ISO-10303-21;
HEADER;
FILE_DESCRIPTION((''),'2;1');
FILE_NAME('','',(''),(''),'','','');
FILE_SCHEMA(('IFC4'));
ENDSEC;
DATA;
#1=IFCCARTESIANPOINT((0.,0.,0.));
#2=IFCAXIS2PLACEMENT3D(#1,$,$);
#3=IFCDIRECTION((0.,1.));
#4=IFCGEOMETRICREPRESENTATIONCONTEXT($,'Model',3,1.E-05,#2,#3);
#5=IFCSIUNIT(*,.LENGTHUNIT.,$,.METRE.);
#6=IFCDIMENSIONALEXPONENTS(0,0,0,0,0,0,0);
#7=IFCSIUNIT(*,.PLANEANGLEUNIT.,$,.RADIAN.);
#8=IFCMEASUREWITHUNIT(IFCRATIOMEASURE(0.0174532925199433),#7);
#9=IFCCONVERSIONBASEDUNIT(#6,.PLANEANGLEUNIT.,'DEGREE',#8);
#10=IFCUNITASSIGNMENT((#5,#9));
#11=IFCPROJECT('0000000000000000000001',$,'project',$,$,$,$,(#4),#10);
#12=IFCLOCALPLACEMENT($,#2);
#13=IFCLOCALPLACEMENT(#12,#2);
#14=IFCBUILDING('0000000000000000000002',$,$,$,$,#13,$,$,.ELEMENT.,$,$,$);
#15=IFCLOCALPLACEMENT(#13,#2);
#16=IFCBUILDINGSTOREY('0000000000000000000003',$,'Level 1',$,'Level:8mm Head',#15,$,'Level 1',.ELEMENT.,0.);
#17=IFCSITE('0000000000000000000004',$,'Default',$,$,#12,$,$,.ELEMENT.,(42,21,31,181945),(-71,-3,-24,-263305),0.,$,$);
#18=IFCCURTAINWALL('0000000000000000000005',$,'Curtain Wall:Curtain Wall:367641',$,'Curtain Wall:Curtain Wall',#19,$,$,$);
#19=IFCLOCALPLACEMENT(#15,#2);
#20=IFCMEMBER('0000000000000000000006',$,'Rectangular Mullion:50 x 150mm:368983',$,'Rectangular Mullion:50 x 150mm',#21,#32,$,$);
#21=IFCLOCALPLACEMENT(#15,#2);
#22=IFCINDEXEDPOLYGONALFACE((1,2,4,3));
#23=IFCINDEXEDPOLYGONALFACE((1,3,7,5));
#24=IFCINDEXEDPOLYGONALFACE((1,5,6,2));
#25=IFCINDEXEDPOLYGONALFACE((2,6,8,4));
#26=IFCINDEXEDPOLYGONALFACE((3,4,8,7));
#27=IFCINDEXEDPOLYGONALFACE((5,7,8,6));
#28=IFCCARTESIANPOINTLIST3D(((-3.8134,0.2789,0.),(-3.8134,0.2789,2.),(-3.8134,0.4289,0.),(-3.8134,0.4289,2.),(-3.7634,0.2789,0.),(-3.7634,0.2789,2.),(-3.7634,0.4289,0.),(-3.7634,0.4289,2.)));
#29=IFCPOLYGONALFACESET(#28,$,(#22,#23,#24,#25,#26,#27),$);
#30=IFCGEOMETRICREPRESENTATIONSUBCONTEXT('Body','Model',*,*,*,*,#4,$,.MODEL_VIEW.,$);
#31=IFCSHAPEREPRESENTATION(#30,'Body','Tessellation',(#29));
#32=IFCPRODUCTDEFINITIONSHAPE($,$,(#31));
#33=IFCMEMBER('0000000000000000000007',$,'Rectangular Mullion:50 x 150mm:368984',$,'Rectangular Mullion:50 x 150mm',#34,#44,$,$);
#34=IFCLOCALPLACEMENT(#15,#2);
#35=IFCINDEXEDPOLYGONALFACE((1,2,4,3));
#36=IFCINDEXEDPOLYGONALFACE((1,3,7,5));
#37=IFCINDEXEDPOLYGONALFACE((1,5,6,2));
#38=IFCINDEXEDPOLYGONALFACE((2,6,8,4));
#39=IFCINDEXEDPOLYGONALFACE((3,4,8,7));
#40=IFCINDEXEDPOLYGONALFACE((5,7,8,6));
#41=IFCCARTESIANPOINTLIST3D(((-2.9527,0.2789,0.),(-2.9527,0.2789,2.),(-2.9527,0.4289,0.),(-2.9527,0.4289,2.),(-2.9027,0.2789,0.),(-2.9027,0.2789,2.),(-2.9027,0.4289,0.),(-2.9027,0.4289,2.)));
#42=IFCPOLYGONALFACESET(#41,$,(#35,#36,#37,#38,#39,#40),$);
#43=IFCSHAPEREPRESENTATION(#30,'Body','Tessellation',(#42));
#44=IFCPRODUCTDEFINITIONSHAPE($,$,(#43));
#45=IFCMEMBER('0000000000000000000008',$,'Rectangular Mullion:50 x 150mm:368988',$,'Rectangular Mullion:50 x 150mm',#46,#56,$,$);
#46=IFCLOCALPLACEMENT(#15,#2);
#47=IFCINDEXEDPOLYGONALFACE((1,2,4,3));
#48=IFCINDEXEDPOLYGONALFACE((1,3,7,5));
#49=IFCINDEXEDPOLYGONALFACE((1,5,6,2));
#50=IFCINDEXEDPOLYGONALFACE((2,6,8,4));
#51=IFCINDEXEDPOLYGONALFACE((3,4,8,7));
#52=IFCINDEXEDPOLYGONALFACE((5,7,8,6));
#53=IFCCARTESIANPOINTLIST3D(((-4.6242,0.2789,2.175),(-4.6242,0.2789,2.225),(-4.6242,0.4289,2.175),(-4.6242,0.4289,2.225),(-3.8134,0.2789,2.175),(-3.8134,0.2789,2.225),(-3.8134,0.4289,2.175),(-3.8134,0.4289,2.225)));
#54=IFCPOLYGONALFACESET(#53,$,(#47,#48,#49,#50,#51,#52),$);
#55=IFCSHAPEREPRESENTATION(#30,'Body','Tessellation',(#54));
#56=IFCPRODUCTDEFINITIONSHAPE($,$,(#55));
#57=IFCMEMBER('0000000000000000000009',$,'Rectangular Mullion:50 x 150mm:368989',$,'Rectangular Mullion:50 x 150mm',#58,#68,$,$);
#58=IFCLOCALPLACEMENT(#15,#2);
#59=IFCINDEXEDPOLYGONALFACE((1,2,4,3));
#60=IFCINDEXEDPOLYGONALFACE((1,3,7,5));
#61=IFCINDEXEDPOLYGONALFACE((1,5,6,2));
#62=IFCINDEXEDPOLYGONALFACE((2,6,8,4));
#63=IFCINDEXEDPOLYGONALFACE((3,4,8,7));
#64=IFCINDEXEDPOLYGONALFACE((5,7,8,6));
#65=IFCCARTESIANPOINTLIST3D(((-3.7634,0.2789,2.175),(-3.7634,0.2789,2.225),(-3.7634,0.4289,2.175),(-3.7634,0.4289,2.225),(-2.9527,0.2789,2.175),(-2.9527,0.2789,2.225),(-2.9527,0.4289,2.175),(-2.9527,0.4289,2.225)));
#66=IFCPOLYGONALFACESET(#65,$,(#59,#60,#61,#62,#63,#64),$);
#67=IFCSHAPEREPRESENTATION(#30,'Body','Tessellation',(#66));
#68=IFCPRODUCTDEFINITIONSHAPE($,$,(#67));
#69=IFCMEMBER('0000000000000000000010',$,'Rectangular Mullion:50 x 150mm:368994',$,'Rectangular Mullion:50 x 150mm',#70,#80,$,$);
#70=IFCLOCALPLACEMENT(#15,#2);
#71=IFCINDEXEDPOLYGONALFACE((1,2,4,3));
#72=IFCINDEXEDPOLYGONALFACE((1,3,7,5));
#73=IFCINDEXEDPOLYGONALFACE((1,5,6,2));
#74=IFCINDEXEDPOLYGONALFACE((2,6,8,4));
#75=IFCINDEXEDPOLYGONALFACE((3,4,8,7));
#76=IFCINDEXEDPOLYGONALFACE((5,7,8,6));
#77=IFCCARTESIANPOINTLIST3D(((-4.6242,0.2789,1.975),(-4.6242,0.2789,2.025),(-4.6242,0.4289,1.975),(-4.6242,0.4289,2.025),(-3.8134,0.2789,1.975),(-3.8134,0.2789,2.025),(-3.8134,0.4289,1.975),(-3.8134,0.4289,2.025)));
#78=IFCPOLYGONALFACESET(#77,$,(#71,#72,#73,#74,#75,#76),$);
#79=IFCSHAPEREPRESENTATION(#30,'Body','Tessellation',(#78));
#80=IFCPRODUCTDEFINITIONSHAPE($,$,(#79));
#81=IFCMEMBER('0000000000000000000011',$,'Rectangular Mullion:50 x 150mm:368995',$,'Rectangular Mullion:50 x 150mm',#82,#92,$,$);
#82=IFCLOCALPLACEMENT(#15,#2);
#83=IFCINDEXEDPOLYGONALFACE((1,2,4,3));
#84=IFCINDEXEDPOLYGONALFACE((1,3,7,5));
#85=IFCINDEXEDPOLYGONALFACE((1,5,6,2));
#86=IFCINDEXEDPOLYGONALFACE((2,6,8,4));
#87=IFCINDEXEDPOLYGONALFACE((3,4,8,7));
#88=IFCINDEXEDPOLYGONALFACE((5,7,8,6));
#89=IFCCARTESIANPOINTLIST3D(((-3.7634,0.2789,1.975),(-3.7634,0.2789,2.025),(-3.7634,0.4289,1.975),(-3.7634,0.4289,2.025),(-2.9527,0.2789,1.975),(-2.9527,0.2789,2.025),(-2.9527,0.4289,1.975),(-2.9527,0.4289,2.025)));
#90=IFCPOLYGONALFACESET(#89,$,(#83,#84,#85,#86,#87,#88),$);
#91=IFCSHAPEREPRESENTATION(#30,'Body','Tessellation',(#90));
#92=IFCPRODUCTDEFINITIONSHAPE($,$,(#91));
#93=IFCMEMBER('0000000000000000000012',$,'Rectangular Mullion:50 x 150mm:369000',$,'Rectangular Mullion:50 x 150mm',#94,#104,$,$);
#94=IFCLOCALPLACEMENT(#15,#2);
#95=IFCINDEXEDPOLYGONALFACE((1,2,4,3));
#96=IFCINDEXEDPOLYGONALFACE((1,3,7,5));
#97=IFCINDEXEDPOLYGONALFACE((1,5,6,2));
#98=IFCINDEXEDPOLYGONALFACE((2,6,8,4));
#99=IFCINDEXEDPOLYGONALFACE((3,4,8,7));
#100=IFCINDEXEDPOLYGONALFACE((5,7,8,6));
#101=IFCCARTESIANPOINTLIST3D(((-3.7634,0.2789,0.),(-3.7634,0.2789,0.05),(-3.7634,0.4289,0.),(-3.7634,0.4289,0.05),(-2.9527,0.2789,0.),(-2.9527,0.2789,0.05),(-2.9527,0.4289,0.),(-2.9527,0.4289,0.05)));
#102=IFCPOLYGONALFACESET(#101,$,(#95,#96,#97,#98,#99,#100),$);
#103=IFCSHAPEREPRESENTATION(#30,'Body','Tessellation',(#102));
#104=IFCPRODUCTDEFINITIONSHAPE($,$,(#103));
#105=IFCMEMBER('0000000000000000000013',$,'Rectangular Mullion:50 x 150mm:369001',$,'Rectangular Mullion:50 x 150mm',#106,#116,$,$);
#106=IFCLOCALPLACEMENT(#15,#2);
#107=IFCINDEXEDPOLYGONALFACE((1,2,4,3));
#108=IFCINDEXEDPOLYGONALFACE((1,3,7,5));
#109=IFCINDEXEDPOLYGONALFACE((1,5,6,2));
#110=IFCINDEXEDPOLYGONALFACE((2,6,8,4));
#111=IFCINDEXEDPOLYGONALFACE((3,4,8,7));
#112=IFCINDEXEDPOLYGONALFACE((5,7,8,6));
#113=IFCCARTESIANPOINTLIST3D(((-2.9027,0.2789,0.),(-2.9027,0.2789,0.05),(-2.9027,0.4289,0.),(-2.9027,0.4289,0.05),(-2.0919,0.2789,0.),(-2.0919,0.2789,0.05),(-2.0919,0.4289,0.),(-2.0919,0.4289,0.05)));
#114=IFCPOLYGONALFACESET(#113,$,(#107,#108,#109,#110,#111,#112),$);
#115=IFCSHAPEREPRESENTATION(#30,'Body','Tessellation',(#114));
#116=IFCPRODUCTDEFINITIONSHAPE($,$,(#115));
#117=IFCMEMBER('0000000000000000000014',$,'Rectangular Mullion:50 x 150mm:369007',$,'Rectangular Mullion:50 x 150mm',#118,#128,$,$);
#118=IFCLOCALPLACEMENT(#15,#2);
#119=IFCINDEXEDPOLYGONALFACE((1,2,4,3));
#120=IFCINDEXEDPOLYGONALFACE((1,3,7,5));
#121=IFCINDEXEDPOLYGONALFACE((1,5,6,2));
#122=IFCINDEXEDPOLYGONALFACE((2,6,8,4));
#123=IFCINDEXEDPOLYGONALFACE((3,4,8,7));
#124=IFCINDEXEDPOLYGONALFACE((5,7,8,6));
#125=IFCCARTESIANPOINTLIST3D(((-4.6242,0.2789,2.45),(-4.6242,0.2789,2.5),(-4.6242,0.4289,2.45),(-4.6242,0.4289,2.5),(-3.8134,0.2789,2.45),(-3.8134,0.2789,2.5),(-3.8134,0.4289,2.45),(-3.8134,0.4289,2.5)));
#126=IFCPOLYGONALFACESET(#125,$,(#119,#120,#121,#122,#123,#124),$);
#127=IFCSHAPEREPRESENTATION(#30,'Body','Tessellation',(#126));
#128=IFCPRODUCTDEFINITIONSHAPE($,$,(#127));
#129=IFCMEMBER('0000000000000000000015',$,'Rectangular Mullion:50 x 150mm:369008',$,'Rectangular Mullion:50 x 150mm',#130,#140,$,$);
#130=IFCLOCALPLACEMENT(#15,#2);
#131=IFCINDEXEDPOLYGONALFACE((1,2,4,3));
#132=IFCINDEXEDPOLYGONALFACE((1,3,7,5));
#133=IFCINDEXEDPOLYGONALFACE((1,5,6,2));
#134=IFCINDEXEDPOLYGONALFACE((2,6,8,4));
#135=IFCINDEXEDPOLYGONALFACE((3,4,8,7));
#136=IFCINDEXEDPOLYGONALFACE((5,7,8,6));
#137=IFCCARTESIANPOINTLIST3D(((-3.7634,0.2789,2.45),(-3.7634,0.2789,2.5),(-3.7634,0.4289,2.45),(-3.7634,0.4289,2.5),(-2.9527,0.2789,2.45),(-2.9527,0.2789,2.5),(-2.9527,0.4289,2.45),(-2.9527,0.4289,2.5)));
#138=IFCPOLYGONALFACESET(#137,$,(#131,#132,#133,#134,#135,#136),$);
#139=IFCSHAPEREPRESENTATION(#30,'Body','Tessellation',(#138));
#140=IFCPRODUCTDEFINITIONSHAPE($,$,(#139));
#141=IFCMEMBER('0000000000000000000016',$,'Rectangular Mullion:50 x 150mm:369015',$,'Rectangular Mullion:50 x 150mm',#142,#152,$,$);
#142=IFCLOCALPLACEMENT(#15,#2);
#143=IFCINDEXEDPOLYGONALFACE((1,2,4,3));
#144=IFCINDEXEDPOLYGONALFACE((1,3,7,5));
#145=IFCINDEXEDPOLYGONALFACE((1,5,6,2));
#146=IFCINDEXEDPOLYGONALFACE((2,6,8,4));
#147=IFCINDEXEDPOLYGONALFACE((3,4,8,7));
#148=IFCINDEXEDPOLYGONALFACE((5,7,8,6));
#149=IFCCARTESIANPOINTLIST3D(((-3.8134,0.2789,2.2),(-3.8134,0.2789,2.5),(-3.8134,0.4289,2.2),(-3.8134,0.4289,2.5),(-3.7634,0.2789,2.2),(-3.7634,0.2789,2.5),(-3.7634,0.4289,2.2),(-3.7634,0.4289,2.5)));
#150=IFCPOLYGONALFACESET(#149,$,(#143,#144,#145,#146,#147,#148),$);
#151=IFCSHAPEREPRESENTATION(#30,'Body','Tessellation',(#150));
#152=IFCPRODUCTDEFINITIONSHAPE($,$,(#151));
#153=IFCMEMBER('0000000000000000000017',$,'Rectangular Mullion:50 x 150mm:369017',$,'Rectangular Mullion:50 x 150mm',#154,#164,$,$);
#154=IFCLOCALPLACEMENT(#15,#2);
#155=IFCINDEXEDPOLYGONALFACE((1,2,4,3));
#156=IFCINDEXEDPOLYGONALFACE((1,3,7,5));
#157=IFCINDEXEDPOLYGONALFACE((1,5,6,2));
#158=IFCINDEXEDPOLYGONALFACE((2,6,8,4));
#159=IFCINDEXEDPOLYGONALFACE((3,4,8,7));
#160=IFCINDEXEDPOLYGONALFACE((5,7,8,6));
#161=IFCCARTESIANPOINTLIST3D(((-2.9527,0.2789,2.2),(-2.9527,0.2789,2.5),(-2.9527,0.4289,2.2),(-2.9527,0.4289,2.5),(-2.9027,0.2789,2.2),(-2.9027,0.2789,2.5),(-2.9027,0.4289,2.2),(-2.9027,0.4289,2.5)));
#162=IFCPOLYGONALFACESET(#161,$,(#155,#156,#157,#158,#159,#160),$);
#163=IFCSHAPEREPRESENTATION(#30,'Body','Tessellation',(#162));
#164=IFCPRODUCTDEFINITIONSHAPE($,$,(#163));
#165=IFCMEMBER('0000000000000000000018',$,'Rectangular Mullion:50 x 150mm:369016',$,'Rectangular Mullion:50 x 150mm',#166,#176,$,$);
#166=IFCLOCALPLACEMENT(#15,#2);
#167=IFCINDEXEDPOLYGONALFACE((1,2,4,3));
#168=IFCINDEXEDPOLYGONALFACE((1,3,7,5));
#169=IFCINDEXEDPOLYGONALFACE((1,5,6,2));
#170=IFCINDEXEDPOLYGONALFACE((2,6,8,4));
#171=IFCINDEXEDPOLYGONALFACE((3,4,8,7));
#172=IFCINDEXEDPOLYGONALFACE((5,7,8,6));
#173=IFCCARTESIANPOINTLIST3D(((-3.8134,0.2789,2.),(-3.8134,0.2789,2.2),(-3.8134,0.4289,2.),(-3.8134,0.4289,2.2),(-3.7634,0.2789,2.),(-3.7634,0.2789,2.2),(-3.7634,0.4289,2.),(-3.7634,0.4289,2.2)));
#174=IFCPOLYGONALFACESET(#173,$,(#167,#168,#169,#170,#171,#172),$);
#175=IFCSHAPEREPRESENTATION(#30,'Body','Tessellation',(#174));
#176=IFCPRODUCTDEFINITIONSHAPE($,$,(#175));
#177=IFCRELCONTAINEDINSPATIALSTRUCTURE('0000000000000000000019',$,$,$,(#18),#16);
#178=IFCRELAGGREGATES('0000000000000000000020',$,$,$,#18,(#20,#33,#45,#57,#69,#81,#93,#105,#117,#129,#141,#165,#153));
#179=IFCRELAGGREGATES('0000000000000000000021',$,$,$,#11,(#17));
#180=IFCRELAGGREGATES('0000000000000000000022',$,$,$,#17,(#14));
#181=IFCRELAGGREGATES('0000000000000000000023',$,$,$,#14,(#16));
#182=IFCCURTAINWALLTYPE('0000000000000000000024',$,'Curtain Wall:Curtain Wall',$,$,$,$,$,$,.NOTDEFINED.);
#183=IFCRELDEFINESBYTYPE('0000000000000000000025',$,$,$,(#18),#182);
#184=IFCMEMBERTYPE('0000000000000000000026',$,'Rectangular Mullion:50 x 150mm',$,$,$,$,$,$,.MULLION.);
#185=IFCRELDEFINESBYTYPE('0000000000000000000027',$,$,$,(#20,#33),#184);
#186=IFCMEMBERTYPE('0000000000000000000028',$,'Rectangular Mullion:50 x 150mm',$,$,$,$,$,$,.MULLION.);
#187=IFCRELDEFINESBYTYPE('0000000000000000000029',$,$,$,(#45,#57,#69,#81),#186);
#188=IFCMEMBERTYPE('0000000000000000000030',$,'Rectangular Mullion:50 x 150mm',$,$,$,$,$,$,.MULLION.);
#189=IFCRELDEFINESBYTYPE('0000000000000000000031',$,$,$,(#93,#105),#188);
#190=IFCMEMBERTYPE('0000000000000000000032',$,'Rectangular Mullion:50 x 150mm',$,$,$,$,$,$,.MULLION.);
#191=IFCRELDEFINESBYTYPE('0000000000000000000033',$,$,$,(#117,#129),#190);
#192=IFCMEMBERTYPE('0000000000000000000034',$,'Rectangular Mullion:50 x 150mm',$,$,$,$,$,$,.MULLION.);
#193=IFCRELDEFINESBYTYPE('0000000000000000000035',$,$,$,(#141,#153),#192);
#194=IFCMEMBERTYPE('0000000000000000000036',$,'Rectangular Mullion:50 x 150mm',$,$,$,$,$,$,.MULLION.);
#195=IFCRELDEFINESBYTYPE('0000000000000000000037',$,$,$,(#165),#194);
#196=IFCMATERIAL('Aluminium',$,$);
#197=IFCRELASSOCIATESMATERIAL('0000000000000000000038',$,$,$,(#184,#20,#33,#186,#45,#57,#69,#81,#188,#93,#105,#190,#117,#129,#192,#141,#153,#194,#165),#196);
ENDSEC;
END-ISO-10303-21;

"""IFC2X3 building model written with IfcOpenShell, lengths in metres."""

from ifc_helpers import new_model, entity, si_unit, converted_unit, direction, frame, origin, origin_2d_with_axis, place, context, subcontext, project, spatial, rectangle, extrude, source, transform, mapped, material, type_object, type_shapes, element, aggregate, save


model = new_model("IFC2X3")

# Units and contexts
model_context = context("Model", 3, precision=1e-05, world=origin(), true_north=direction((0.0, 1.0)))
body_context = subcontext(model_context, "Body", "Model", "MODEL_VIEW")
ifc_project = project(units=[si_unit("LENGTHUNIT", "METRE"), converted_unit("PLANEANGLEUNIT", "DEGREE", entity("IfcRatioMeasure", 0.0174532925199433), si_unit("PLANEANGLEUNIT", "RADIAN"), dimensions=[0, 0, 0, 0, 0, 0, 0])], contexts=[model_context])

# Site, building, storey
site_placement = place(None, origin())
site = spatial("IfcSite", under=ifc_project, at=site_placement, Name="Default", CompositionType="ELEMENT", RefLatitude=(42, 21, 31, 181945), RefLongitude=(-71, -3, -24, -263305), RefElevation=0.0)
building_placement = place(site_placement, origin())
building = spatial("IfcBuilding", under=site, at=building_placement, CompositionType="ELEMENT")
storey_placement = place(building_placement, origin())
storey = spatial("IfcBuildingStorey", under=building, at=storey_placement, Name="Level 1", ObjectType="Level:8mm Head", LongName="Level 1", CompositionType="ELEMENT", Elevation=0.0)

# Curtain wall, members
curtain_wall_type = type_object("IfcCurtainWallType", Name="Curtain Wall:Curtain Wall", PredefinedType="NOTDEFINED")
curtain_wall_placement = place(storey_placement, origin())
curtain_wall = element("IfcCurtainWall", 1, at=curtain_wall_placement, inside=storey, type_object=curtain_wall_type, Name="Curtain Wall:Curtain Wall:367641", ObjectType="Curtain Wall:Curtain Wall")
ifc_material_1 = material(Name="Aluminium")
member_type_1 = type_object("IfcMemberType", Name="Rectangular Mullion:50 x 150mm", PredefinedType="MULLION", material=ifc_material_1)
shared_shape_1 = source(origin(), body_context, "Body", "SweptSolid", [
    extrude(rectangle(XDim=0.15, YDim=0.05, at=origin_2d_with_axis()), frame((0.0, 0.0, -2.0), z_axis=(0.0, 0.0, 1.0), x_axis=(0.0, -1.0, 0.0)), (0.0, 0.0, 1.0), 2.0),
])
type_shapes(member_type_1, [shared_shape_1])
member_1_placement = place(storey_placement, frame((-3.7884, 0.3539, 0.0), z_axis=(0.0, 0.0, -1.0), x_axis=(1.0, 0.0, 0.0)))
member_1 = element("IfcMember", 2, at=member_1_placement, type_object=member_type_1, material=ifc_material_1, Name="Rectangular Mullion:50 x 150mm:368983", ObjectType="Rectangular Mullion:50 x 150mm", context=body_context, shape_type="MappedRepresentation", body=[
    mapped(shared_shape_1, transform((0.0, 0.0, 0.0), scale=1.0)),
])
member_2_placement = place(storey_placement, frame((-2.9277, 0.3539, 0.0), z_axis=(0.0, 0.0, -1.0), x_axis=(1.0, 0.0, 0.0)))
member_2 = element("IfcMember", 3, at=member_2_placement, type_object=member_type_1, material=ifc_material_1, Name="Rectangular Mullion:50 x 150mm:368984", ObjectType="Rectangular Mullion:50 x 150mm", context=body_context, shape_type="MappedRepresentation", body=[
    mapped(shared_shape_1, transform((0.0, 0.0, 0.0), scale=1.0)),
])
member_type_2 = type_object("IfcMemberType", Name="Rectangular Mullion:50 x 150mm", PredefinedType="MULLION", material=ifc_material_1)
shared_shape_2 = source(origin(), body_context, "Body", "SweptSolid", [
    extrude(rectangle(XDim=0.15, YDim=0.05, at=origin_2d_with_axis()), frame((0.0, 0.0, -0.8107), z_axis=(0.0, 0.0, 1.0), x_axis=(0.0, -1.0, 0.0)), (0.0, 0.0, 1.0), 0.8107),
])
type_shapes(member_type_2, [shared_shape_2])
member_3_placement = place(storey_placement, frame((-3.8134, 0.3539, 2.2), z_axis=(1.0, 0.0, 0.0), x_axis=(0.0, 0.0, 1.0)))
member_3 = element("IfcMember", 4, at=member_3_placement, type_object=member_type_2, material=ifc_material_1, Name="Rectangular Mullion:50 x 150mm:368988", ObjectType="Rectangular Mullion:50 x 150mm", context=body_context, shape_type="MappedRepresentation", body=[
    mapped(shared_shape_2, transform((0.0, 0.0, 0.0), scale=1.0)),
])
member_4_placement = place(storey_placement, frame((-2.9527, 0.3539, 2.2), z_axis=(1.0, 0.0, 0.0), x_axis=(0.0, 0.0, 1.0)))
member_4 = element("IfcMember", 5, at=member_4_placement, type_object=member_type_2, material=ifc_material_1, Name="Rectangular Mullion:50 x 150mm:368989", ObjectType="Rectangular Mullion:50 x 150mm", context=body_context, shape_type="MappedRepresentation", body=[
    mapped(shared_shape_2, transform((0.0, 0.0, 0.0), scale=1.0)),
])
member_5_placement = place(storey_placement, frame((-3.8134, 0.3539, 2.0), z_axis=(1.0, 0.0, 0.0), x_axis=(0.0, 0.0, 1.0)))
member_5 = element("IfcMember", 6, at=member_5_placement, type_object=member_type_2, material=ifc_material_1, Name="Rectangular Mullion:50 x 150mm:368994", ObjectType="Rectangular Mullion:50 x 150mm", context=body_context, shape_type="MappedRepresentation", body=[
    mapped(shared_shape_2, transform((0.0, 0.0, 0.0), scale=1.0)),
])
member_6_placement = place(storey_placement, frame((-2.9527, 0.3539, 2.0), z_axis=(1.0, 0.0, 0.0), x_axis=(0.0, 0.0, 1.0)))
member_6 = element("IfcMember", 7, at=member_6_placement, type_object=member_type_2, material=ifc_material_1, Name="Rectangular Mullion:50 x 150mm:368995", ObjectType="Rectangular Mullion:50 x 150mm", context=body_context, shape_type="MappedRepresentation", body=[
    mapped(shared_shape_2, transform((0.0, 0.0, 0.0), scale=1.0)),
])
member_type_3 = type_object("IfcMemberType", Name="Rectangular Mullion:50 x 150mm", PredefinedType="MULLION", material=ifc_material_1)
shared_shape_3 = source(origin(), body_context, "Body", "SweptSolid", [
    extrude(rectangle(XDim=0.15, YDim=0.05, at=origin_2d_with_axis()), frame((-0.025, 0.0, -0.8107), z_axis=(0.0, 0.0, 1.0), x_axis=(0.0, -1.0, 0.0)), (0.0, 0.0, 1.0), 0.8107),
])
type_shapes(member_type_3, [shared_shape_3])
member_7_placement = place(storey_placement, frame((-3.7634, 0.3539, 0.0), z_axis=(-1.0, 0.0, 0.0), x_axis=(0.0, 0.0, -1.0)))
member_7 = element("IfcMember", 8, at=member_7_placement, type_object=member_type_3, material=ifc_material_1, Name="Rectangular Mullion:50 x 150mm:369000", ObjectType="Rectangular Mullion:50 x 150mm", context=body_context, shape_type="MappedRepresentation", body=[
    mapped(shared_shape_3, transform((0.0, 0.0, 0.0), scale=1.0)),
])
member_8_placement = place(storey_placement, frame((-2.9027, 0.3539, 0.0), z_axis=(-1.0, 0.0, 0.0), x_axis=(0.0, 0.0, -1.0)))
member_8 = element("IfcMember", 9, at=member_8_placement, type_object=member_type_3, material=ifc_material_1, Name="Rectangular Mullion:50 x 150mm:369001", ObjectType="Rectangular Mullion:50 x 150mm", context=body_context, shape_type="MappedRepresentation", body=[
    mapped(shared_shape_3, transform((0.0, 0.0, 0.0), scale=1.0)),
])
member_type_4 = type_object("IfcMemberType", Name="Rectangular Mullion:50 x 150mm", PredefinedType="MULLION", material=ifc_material_1)
shared_shape_4 = source(origin(), body_context, "Body", "SweptSolid", [
    extrude(rectangle(XDim=0.15, YDim=0.05, at=origin_2d_with_axis()), frame((-0.025, 0.0, -0.8107), z_axis=(0.0, 0.0, 1.0), x_axis=(0.0, -1.0, 0.0)), (0.0, 0.0, 1.0), 0.8107),
])
type_shapes(member_type_4, [shared_shape_4])
member_9_placement = place(storey_placement, frame((-3.8134, 0.3539, 2.5), z_axis=(1.0, 0.0, 0.0), x_axis=(0.0, 0.0, 1.0)))
member_9 = element("IfcMember", 10, at=member_9_placement, type_object=member_type_4, material=ifc_material_1, Name="Rectangular Mullion:50 x 150mm:369007", ObjectType="Rectangular Mullion:50 x 150mm", context=body_context, shape_type="MappedRepresentation", body=[
    mapped(shared_shape_4, transform((0.0, 0.0, 0.0), scale=1.0)),
])
member_10_placement = place(storey_placement, frame((-2.9527, 0.3539, 2.5), z_axis=(1.0, 0.0, 0.0), x_axis=(0.0, 0.0, 1.0)))
member_10 = element("IfcMember", 11, at=member_10_placement, type_object=member_type_4, material=ifc_material_1, Name="Rectangular Mullion:50 x 150mm:369008", ObjectType="Rectangular Mullion:50 x 150mm", context=body_context, shape_type="MappedRepresentation", body=[
    mapped(shared_shape_4, transform((0.0, 0.0, 0.0), scale=1.0)),
])
member_type_5 = type_object("IfcMemberType", Name="Rectangular Mullion:50 x 150mm", PredefinedType="MULLION", material=ifc_material_1)
shared_shape_5 = source(origin(), body_context, "Body", "SweptSolid", [
    extrude(rectangle(XDim=0.15, YDim=0.05, at=origin_2d_with_axis()), frame((0.0, 0.0, -0.3), z_axis=(0.0, 0.0, 1.0), x_axis=(0.0, -1.0, 0.0)), (0.0, 0.0, 1.0), 0.3),
])
type_shapes(member_type_5, [shared_shape_5])
member_11_placement = place(storey_placement, frame((-3.7884, 0.3539, 2.2), z_axis=(0.0, 0.0, -1.0), x_axis=(1.0, 0.0, 0.0)))
member_11 = element("IfcMember", 12, at=member_11_placement, type_object=member_type_5, material=ifc_material_1, Name="Rectangular Mullion:50 x 150mm:369015", ObjectType="Rectangular Mullion:50 x 150mm", context=body_context, shape_type="MappedRepresentation", body=[
    mapped(shared_shape_5, transform((0.0, 0.0, 0.0), scale=1.0)),
])
member_12_placement = place(storey_placement, frame((-2.9277, 0.3539, 2.2), z_axis=(0.0, 0.0, -1.0), x_axis=(1.0, 0.0, 0.0)))
member_12 = element("IfcMember", 13, at=member_12_placement, type_object=member_type_5, material=ifc_material_1, Name="Rectangular Mullion:50 x 150mm:369017", ObjectType="Rectangular Mullion:50 x 150mm", context=body_context, shape_type="MappedRepresentation", body=[
    mapped(shared_shape_5, transform((0.0, 0.0, 0.0), scale=1.0)),
])
member_type_6 = type_object("IfcMemberType", Name="Rectangular Mullion:50 x 150mm", PredefinedType="MULLION", material=ifc_material_1)
shared_shape_6 = source(origin(), body_context, "Body", "SweptSolid", [
    extrude(rectangle(XDim=0.15, YDim=0.05, at=origin_2d_with_axis()), frame((0.0, 0.0, -0.2), z_axis=(0.0, 0.0, 1.0), x_axis=(0.0, -1.0, 0.0)), (0.0, 0.0, 1.0), 0.2),
])
type_shapes(member_type_6, [shared_shape_6])
member_13_placement = place(storey_placement, frame((-3.7884, 0.3539, 2.0), z_axis=(0.0, 0.0, -1.0), x_axis=(1.0, 0.0, 0.0)))
member_13 = element("IfcMember", 14, at=member_13_placement, type_object=member_type_6, material=ifc_material_1, Name="Rectangular Mullion:50 x 150mm:369016", ObjectType="Rectangular Mullion:50 x 150mm", context=body_context, shape_type="MappedRepresentation", body=[
    mapped(shared_shape_6, transform((0.0, 0.0, 0.0), scale=1.0)),
])
aggregate(curtain_wall, [member_1, member_2, member_3, member_4, member_5, member_6, member_7, member_8, member_9, member_10, member_11, member_13, member_12])

save(model, "model.ifc")
